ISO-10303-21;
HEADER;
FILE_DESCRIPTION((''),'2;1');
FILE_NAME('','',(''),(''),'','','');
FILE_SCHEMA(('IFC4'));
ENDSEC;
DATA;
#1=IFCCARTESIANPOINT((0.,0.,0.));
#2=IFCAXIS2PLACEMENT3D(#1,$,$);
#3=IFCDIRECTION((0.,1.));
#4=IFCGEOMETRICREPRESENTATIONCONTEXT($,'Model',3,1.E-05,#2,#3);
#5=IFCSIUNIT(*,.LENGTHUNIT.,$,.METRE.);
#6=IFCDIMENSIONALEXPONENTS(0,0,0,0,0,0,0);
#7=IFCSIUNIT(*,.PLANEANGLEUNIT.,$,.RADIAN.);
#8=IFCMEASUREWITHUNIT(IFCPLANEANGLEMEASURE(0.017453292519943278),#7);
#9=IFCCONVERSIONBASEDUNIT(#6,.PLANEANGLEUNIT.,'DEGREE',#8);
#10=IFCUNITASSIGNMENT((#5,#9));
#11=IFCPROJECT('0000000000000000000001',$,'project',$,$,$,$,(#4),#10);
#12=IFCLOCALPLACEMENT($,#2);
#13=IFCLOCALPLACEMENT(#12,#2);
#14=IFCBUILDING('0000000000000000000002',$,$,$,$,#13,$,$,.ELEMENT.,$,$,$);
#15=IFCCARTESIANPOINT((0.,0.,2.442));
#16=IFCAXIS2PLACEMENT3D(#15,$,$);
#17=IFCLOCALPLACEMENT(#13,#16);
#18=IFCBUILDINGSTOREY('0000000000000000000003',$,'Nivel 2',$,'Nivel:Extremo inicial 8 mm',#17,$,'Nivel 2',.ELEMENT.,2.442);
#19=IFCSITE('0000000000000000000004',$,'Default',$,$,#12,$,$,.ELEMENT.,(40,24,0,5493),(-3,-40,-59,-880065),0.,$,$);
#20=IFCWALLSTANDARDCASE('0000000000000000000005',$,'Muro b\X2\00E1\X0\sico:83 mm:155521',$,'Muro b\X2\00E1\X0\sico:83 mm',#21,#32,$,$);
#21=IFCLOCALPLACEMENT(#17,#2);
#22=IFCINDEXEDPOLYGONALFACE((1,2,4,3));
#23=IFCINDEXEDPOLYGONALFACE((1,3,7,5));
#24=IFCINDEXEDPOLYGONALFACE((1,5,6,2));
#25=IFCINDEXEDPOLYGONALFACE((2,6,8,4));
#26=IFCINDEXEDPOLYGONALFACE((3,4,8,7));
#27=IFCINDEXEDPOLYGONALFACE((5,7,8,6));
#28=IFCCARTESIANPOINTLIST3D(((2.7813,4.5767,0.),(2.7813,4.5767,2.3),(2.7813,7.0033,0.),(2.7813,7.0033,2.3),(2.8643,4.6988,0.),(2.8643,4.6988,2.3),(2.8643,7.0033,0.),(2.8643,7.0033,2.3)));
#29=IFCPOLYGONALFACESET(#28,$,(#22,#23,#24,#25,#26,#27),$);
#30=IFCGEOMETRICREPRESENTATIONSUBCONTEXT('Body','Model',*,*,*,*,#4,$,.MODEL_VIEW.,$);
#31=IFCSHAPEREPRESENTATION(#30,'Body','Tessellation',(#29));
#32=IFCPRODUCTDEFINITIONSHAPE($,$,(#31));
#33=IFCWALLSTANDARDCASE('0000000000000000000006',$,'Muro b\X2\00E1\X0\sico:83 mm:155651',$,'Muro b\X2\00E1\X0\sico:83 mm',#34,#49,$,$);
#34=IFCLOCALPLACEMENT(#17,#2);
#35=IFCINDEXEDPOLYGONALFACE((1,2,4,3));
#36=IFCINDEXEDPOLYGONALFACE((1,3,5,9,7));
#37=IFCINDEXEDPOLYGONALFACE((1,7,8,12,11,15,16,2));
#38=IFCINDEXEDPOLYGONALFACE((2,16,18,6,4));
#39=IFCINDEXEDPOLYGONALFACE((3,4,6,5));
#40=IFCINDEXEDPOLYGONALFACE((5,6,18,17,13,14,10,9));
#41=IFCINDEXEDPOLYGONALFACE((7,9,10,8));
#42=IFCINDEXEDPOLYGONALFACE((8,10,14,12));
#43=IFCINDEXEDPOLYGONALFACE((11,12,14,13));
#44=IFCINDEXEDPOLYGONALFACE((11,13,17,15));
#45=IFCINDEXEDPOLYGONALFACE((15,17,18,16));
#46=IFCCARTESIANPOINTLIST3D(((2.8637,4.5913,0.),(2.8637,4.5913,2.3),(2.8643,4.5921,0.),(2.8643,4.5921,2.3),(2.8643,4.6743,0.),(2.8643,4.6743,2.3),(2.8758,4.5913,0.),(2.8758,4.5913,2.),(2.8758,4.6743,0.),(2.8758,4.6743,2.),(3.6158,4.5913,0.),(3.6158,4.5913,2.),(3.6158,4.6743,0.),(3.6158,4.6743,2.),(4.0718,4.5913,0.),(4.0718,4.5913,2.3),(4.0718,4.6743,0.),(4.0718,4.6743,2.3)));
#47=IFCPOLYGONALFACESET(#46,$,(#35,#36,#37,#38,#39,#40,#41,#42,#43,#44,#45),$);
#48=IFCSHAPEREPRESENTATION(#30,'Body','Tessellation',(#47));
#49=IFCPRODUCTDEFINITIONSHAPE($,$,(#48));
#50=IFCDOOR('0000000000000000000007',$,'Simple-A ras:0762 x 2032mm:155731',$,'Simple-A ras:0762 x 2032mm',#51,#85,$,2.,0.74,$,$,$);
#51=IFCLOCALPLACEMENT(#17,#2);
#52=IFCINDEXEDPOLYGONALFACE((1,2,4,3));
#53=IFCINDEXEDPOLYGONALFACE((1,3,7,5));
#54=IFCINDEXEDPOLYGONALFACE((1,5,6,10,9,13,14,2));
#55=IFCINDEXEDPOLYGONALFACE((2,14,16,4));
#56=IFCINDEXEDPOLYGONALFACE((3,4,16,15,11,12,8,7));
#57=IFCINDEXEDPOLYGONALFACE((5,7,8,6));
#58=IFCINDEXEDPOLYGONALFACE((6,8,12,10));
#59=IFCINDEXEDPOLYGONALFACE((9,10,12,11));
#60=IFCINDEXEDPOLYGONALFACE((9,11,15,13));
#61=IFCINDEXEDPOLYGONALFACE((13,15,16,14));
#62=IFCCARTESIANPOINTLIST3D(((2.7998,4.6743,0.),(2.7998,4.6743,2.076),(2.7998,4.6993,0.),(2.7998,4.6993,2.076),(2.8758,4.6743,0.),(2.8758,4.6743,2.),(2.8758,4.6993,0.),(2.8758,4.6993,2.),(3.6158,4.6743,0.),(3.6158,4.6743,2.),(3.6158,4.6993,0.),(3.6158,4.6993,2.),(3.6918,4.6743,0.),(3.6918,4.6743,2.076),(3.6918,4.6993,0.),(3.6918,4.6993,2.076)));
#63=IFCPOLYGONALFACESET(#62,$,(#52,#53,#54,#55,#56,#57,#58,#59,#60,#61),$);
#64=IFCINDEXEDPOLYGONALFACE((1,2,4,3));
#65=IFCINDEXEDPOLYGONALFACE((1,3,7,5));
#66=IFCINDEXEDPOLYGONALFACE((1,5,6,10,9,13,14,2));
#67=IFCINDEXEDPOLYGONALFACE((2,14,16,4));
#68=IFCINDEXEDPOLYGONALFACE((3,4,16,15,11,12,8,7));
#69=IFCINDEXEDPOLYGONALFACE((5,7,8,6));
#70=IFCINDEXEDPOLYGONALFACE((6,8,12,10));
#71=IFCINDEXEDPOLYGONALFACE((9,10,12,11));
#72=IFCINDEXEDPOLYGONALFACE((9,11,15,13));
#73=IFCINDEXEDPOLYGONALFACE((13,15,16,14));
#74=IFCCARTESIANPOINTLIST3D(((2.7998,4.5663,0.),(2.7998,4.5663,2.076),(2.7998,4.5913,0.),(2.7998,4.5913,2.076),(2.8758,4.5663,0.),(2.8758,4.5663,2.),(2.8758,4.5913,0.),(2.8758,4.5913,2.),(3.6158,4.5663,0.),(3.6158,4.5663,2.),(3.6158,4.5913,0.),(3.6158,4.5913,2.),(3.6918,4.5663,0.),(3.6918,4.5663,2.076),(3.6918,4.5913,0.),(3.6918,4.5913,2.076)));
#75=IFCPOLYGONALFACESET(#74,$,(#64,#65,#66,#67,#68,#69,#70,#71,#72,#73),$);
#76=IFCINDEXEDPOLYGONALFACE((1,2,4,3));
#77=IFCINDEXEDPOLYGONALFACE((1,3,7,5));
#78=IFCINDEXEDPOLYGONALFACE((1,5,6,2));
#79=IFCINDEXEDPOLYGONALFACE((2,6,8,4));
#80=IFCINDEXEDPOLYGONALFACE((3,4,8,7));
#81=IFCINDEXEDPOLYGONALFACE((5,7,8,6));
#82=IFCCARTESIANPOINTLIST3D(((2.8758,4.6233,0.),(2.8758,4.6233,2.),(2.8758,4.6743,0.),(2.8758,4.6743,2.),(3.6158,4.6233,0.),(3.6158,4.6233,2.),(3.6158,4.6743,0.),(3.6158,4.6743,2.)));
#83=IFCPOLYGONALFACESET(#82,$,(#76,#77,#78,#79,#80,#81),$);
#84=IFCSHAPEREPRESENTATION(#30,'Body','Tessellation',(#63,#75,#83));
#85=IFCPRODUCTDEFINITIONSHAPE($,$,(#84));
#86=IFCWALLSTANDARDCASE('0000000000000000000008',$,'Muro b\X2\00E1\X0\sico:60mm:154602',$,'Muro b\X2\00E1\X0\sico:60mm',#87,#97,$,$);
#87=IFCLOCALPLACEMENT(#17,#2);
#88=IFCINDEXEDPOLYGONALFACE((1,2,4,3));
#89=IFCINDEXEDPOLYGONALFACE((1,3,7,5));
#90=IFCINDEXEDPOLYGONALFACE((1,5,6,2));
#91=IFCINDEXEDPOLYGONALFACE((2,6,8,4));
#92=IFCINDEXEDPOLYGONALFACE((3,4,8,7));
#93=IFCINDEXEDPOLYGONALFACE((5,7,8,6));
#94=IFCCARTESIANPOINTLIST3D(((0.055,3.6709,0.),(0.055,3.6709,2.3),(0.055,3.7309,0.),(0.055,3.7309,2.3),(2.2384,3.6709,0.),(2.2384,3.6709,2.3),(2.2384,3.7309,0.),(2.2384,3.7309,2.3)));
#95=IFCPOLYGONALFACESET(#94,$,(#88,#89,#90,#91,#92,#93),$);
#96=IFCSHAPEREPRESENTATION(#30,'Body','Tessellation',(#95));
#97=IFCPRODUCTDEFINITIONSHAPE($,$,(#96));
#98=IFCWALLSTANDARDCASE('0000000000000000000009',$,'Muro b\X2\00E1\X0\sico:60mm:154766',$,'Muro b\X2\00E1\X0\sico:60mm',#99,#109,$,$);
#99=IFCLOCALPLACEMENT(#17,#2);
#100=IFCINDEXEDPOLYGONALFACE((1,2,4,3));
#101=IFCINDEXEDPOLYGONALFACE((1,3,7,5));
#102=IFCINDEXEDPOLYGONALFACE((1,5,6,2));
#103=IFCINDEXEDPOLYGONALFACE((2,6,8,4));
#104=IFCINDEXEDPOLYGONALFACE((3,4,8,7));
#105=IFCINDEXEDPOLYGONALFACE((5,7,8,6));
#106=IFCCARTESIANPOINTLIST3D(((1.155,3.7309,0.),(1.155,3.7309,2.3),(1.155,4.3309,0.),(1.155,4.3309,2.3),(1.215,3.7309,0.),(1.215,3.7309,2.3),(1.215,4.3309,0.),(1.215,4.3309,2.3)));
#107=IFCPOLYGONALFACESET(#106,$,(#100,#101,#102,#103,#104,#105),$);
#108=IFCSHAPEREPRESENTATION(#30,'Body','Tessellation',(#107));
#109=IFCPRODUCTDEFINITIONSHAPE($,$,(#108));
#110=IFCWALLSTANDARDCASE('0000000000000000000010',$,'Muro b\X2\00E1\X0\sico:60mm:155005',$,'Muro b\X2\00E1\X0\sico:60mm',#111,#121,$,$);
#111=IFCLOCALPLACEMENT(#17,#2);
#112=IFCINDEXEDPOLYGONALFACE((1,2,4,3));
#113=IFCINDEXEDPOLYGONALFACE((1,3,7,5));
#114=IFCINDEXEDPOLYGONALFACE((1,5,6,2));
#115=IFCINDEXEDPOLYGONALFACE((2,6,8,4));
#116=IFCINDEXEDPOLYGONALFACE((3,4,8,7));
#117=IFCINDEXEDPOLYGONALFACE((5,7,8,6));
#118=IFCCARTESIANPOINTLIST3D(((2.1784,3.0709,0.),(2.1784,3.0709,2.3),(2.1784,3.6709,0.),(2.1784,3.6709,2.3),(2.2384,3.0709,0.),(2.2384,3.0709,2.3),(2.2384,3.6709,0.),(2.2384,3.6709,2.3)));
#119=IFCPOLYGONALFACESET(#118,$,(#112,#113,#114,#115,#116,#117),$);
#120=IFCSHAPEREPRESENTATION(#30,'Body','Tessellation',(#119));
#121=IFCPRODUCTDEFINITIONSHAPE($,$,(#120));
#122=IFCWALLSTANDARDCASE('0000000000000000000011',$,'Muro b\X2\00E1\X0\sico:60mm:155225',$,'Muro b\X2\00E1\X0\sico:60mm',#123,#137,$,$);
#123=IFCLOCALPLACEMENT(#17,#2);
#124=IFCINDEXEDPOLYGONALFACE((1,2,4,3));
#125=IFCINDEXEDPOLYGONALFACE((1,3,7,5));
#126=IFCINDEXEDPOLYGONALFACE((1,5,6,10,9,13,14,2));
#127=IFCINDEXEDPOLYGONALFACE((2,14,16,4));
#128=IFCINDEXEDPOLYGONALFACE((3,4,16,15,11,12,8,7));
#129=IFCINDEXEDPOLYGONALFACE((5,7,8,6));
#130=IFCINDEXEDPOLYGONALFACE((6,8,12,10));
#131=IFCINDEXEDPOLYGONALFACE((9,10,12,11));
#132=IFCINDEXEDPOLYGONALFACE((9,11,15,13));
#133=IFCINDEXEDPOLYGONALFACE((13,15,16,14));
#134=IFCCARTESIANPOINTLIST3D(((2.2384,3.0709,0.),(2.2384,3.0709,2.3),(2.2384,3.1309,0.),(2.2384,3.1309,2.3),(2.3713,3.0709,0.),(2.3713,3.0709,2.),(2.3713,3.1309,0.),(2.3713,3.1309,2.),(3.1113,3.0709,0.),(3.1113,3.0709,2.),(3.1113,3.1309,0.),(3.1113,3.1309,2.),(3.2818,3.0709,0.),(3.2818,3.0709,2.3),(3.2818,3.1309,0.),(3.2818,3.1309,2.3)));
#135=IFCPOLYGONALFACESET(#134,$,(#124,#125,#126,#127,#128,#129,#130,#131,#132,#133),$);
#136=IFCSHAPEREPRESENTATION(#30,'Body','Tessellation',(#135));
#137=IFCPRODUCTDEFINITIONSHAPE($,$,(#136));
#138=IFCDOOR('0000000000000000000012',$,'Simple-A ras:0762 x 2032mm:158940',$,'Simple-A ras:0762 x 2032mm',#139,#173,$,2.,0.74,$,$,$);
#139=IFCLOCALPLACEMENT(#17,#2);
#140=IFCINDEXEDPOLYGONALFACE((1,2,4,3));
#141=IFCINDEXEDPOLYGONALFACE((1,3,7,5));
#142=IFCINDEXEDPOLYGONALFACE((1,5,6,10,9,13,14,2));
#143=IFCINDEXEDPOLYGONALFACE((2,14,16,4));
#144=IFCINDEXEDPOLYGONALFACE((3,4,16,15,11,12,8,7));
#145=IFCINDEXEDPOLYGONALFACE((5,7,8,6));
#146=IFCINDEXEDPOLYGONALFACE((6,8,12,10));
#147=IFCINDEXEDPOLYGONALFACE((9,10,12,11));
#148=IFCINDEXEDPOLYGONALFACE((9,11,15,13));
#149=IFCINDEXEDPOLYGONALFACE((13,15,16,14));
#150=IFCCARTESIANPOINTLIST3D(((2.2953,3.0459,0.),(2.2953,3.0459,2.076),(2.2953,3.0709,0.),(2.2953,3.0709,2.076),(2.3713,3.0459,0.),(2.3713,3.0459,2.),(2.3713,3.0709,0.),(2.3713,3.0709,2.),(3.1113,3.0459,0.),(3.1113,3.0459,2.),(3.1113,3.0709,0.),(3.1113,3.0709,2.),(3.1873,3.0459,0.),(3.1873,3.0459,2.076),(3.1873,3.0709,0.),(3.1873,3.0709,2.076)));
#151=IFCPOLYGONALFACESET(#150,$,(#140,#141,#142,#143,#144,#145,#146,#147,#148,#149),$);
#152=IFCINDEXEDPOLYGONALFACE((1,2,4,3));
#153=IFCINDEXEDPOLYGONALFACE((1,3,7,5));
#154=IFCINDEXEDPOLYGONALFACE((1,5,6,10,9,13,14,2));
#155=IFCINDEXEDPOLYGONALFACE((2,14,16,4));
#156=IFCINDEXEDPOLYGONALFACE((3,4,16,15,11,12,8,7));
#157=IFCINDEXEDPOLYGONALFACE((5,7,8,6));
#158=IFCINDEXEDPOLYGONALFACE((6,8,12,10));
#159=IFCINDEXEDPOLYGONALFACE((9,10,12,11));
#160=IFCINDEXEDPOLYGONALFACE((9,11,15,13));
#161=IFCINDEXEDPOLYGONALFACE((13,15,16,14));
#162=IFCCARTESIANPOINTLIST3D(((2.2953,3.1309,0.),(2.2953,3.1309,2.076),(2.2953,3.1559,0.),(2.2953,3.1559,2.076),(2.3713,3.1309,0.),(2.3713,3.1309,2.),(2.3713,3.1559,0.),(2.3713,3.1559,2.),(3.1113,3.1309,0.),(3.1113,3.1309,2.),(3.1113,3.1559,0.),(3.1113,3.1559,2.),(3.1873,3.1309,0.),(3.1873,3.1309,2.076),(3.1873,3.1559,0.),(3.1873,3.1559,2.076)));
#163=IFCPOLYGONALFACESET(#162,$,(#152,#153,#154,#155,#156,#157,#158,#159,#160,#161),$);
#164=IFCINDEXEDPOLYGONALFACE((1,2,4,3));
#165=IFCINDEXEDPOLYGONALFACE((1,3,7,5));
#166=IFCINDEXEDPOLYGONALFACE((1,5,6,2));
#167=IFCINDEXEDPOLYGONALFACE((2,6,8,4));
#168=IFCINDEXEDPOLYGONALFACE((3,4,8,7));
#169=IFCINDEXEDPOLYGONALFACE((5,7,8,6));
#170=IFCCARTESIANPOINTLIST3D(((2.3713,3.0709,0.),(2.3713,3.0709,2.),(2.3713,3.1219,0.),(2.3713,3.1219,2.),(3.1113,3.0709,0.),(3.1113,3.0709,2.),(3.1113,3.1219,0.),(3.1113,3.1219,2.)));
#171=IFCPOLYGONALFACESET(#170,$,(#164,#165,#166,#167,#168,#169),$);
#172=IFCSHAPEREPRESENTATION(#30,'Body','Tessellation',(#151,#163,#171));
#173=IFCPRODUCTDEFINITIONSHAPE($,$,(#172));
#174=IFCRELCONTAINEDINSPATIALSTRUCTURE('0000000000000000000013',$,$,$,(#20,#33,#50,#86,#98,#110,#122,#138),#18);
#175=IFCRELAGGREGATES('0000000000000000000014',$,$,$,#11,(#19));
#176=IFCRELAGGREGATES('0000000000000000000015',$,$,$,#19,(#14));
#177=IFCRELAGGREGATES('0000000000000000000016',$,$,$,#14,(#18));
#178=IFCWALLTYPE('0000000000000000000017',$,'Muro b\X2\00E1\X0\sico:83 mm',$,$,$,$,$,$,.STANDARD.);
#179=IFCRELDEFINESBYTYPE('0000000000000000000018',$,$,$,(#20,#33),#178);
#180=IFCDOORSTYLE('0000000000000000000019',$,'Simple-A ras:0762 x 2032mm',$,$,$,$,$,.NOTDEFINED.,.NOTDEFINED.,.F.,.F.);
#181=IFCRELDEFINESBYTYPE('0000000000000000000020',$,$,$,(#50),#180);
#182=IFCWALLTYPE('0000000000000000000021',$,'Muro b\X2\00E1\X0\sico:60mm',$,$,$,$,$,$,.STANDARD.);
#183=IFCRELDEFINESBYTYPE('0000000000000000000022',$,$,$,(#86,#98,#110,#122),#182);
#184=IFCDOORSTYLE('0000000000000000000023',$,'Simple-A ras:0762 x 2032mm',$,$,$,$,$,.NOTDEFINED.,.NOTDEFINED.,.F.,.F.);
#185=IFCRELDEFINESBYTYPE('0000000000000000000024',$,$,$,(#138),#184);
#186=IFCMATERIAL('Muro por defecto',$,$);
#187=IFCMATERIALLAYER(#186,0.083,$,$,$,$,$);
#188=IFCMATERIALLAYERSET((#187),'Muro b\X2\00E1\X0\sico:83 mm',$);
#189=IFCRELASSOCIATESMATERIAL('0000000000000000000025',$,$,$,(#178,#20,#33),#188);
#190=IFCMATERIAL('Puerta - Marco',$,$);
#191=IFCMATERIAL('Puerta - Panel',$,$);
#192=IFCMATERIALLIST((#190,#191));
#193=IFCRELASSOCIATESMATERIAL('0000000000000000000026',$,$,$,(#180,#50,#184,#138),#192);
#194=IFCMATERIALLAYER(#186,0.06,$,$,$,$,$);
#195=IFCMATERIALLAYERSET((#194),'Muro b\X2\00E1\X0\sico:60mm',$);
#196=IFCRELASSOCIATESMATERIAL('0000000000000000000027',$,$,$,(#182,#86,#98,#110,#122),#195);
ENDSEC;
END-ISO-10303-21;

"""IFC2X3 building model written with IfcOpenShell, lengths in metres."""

from ifc_helpers import new_model, entity, si_unit, converted_unit, direction, frame, frame_2d, origin, origin_2d_with_axis, place, context, subcontext, project, spatial, polyline, rectangle, outline, extrude, source, transform, mapped, material, material_list, layer, layer_set, layer_usage, type_object, type_shapes, element, fill, save


model = new_model("IFC2X3")

# Units and contexts
model_context = context("Model", 3, precision=1e-05, world=origin(), true_north=direction((0.0, 1.0)))
body_context = subcontext(model_context, "Body", "Model", "MODEL_VIEW")
ifc_project = project(units=[si_unit("LENGTHUNIT", "METRE"), converted_unit("PLANEANGLEUNIT", "DEGREE", entity("IfcPlaneAngleMeasure", 0.017453292519943278), si_unit("PLANEANGLEUNIT", "RADIAN"), dimensions=[0, 0, 0, 0, 0, 0, 0])], contexts=[model_context])

# Site, building, storey
site_placement = place(None, origin())
site = spatial("IfcSite", under=ifc_project, at=site_placement, Name="Default", CompositionType="ELEMENT", RefLatitude=(40, 24, 0, 5493), RefLongitude=(-3, -40, -59, -880065), RefElevation=0.0)
building_placement = place(site_placement, origin())
building = spatial("IfcBuilding", under=site, at=building_placement, CompositionType="ELEMENT")
storey_placement = place(building_placement, frame((0.0, 0.0, 2.442)))
storey = spatial("IfcBuildingStorey", under=building, at=storey_placement, Name="Nivel 2", ObjectType="Nivel:Extremo inicial 8 mm", LongName="Nivel 2", CompositionType="ELEMENT", Elevation=2.442)

# Shared definitions
ifc_material_1 = material(Name="Muro por defecto")

# Wall
ifc_layer_1 = layer(ifc_material_1, 0.083)
ifc_layer_set_1 = layer_set([ifc_layer_1], Name="Muro básico:83 mm")
ifc_layer_usage_1 = layer_usage(ifc_layer_set_1, "AXIS2", "NEGATIVE", 0.0415)
wall_type_1 = type_object("IfcWallType", Name="Muro básico:83 mm", PredefinedType="STANDARD", material=ifc_layer_set_1)
wall_1_placement = place(storey_placement, frame((2.8228, 4.5767, 0.0), z_axis=(0.0, 0.0, 1.0), x_axis=(0.0, 1.0, 0.0)))
element("IfcWallStandardCase", 1, at=wall_1_placement, inside=storey, type_object=wall_type_1, material=ifc_layer_usage_1, Name="Muro básico:83 mm:155521", ObjectType="Muro básico:83 mm", context=body_context, shape_type="SweptSolid", body=[
    extrude(outline(polyline([(2.4266, -0.0415), (2.4266, 0.0415), (0.0, 0.0415), (0.1222, -0.0415), (2.4266, -0.0415)])), origin(), (0.0, 0.0, 1.0), 2.3),
])

# Wall, opening, door
ifc_layer_usage_2 = layer_usage(ifc_layer_set_1, "AXIS2", "NEGATIVE", 0.0415)
wall_2_placement = place(storey_placement, frame((4.0718, 4.6328, 0.0), z_axis=(0.0, 0.0, 1.0), x_axis=(-1.0, 0.0, 0.0)))
wall_2 = element("IfcWallStandardCase", 2, at=wall_2_placement, inside=storey, type_object=wall_type_1, material=ifc_layer_usage_2, Name="Muro básico:83 mm:155651", ObjectType="Muro básico:83 mm", context=body_context, shape_type="SweptSolid", body=[
    extrude(outline(polyline([(0.0, -0.0415), (1.2075, -0.0415), (1.2075, 0.0407), (1.2081, 0.0415), (0.0, 0.0415), (0.0, -0.0415)])), origin(), (0.0, 0.0, 1.0), 2.3),
])
opening_1_placement = place(wall_2_placement, frame((1.196, 0.0415, 0.0)))
opening_1 = element("IfcOpeningElement", 3, at=opening_1_placement, cuts=wall_2, ObjectType="Opening", context=body_context, shape_type="SweptSolid", body=[
    extrude(rectangle(XDim=0.74, YDim=2.0, at=frame_2d((1.0, 0.37), x_axis=(0.0, -1.0))), frame((0.0, 0.0, 0.0), z_axis=(0.0, -1.0, 0.0), x_axis=(0.0, 0.0, 1.0)), (0.0, 0.0, 1.0), 0.083),
])
ifc_material_2 = material(Name="Puerta - Marco")
ifc_material_3 = material(Name="Puerta - Panel")
ifc_material_list_1 = material_list([ifc_material_2, ifc_material_3])
door_style_1 = type_object("IfcDoorStyle", Name="Simple-A ras:0762 x 2032mm", ConstructionType="NOTDEFINED", OperationType="NOTDEFINED", ParameterTakesPrecedence=False, Sizeable=False, material=ifc_material_list_1)
shared_shape_1 = source(origin(), body_context, "Body", "SweptSolid", [
    extrude(outline(polyline([(-0.446, -1.057), (0.446, -1.057), (0.446, 1.019), (0.37, 1.019), (0.37, -0.981), (-0.37, -0.981), (-0.37, 1.019), (-0.446, 1.019), (-0.446, -1.057)])), frame((0.37, 0.108, 1.019), z_axis=(0.0, -1.0, 0.0), x_axis=(-1.0, 0.0, 0.0)), (0.0, 0.0, 1.0), 0.025),
    extrude(outline(polyline([(-1.057, -0.446), (1.019, -0.446), (1.019, -0.37), (-0.981, -0.37), (-0.981, 0.37), (1.019, 0.37), (1.019, 0.446), (-1.057, 0.446), (-1.057, -0.446)])), frame((0.37, 0.0, 1.019), z_axis=(0.0, -1.0, 0.0), x_axis=(0.0, 0.0, -1.0)), (0.0, 0.0, 1.0), 0.025),
    extrude(rectangle(XDim=0.74, YDim=0.051, at=origin_2d_with_axis()), frame((0.37, 0.0575, 0.0)), (0.0, 0.0, 1.0), 2.0),
])
type_shapes(door_style_1, [shared_shape_1])
door_1_placement = place(opening_1_placement, frame((0.0, 0.0, 0.0), z_axis=(0.0, 0.0, 1.0), x_axis=(-1.0, 0.0, 0.0)))
door_1 = element("IfcDoor", 4, at=door_1_placement, inside=storey, type_object=door_style_1, material=ifc_material_list_1, Name="Simple-A ras:0762 x 2032mm:155731", ObjectType="Simple-A ras:0762 x 2032mm", OverallHeight=2.0, OverallWidth=0.74, context=body_context, shape_type="MappedRepresentation", body=[
    mapped(shared_shape_1, transform((0.0, 0.0, 0.0), scale=1.0)),
])
fill(opening_1, door_1)

# Walls
ifc_layer_2 = layer(ifc_material_1, 0.06)
ifc_layer_set_2 = layer_set([ifc_layer_2], Name="Muro básico:60mm")
ifc_layer_usage_3 = layer_usage(ifc_layer_set_2, "AXIS2", "NEGATIVE", 0.03)
wall_type_2 = type_object("IfcWallType", Name="Muro básico:60mm", PredefinedType="STANDARD", material=ifc_layer_set_2)
wall_3_placement = place(storey_placement, frame((0.055, 3.7009, 0.0)))
element("IfcWallStandardCase", 5, at=wall_3_placement, inside=storey, type_object=wall_type_2, material=ifc_layer_usage_3, Name="Muro básico:60mm:154602", ObjectType="Muro básico:60mm", context=body_context, shape_type="SweptSolid", body=[
    extrude(rectangle(XDim=2.1834, YDim=0.06, at=frame_2d((1.0917, 0.0), x_axis=(-1.0, 0.0))), origin(), (0.0, 0.0, 1.0), 2.3),
])
ifc_layer_usage_4 = layer_usage(ifc_layer_set_2, "AXIS2", "NEGATIVE", 0.03)
wall_4_placement = place(storey_placement, frame((1.185, 3.7309, 0.0), z_axis=(0.0, 0.0, 1.0), x_axis=(0.0, 1.0, 0.0)))
element("IfcWallStandardCase", 6, at=wall_4_placement, inside=storey, type_object=wall_type_2, material=ifc_layer_usage_4, Name="Muro básico:60mm:154766", ObjectType="Muro básico:60mm", context=body_context, shape_type="SweptSolid", body=[
    extrude(rectangle(XDim=0.6, YDim=0.06, at=frame_2d((0.3, 0.0), x_axis=(-1.0, 0.0))), origin(), (0.0, 0.0, 1.0), 2.3),
])
ifc_layer_usage_5 = layer_usage(ifc_layer_set_2, "AXIS2", "NEGATIVE", 0.03)
wall_5_placement = place(storey_placement, frame((2.2084, 3.0709, 0.0), z_axis=(0.0, 0.0, 1.0), x_axis=(0.0, 1.0, 0.0)))
element("IfcWallStandardCase", 7, at=wall_5_placement, inside=storey, type_object=wall_type_2, material=ifc_layer_usage_5, Name="Muro básico:60mm:155005", ObjectType="Muro básico:60mm", context=body_context, shape_type="SweptSolid", body=[
    extrude(rectangle(XDim=0.6, YDim=0.06, at=frame_2d((0.3, 0.0), x_axis=(-1.0, 0.0))), origin(), (0.0, 0.0, 1.0), 2.3),
])

# Wall, opening, door
ifc_layer_usage_6 = layer_usage(ifc_layer_set_2, "AXIS2", "NEGATIVE", 0.03)
wall_6_placement = place(storey_placement, frame((2.2384, 3.1009, 0.0)))
wall_6 = element("IfcWallStandardCase", 8, at=wall_6_placement, inside=storey, type_object=wall_type_2, material=ifc_layer_usage_6, Name="Muro básico:60mm:155225", ObjectType="Muro básico:60mm", context=body_context, shape_type="SweptSolid", body=[
    extrude(rectangle(XDim=1.0434, YDim=0.06, at=frame_2d((0.5217, 0.0), x_axis=(-1.0, 0.0))), origin(), (0.0, 0.0, 1.0), 2.3),
])
opening_2_placement = place(wall_6_placement, frame((0.8729, 0.03, 0.0)))
opening_2 = element("IfcOpeningElement", 9, at=opening_2_placement, cuts=wall_6, ObjectType="Opening", context=body_context, shape_type="SweptSolid", body=[
    extrude(rectangle(XDim=0.74, YDim=2.0, at=frame_2d((1.0, 0.37), x_axis=(0.0, -1.0))), frame((0.0, 0.0, 0.0), z_axis=(0.0, -1.0, 0.0), x_axis=(0.0, 0.0, 1.0)), (0.0, 0.0, 1.0), 0.06),
])
door_style_2 = type_object("IfcDoorStyle", Name="Simple-A ras:0762 x 2032mm", ConstructionType="NOTDEFINED", OperationType="NOTDEFINED", ParameterTakesPrecedence=False, Sizeable=False, material=ifc_material_list_1)
shared_shape_2 = source(origin(), body_context, "Body", "SweptSolid", [
    extrude(outline(polyline([(-0.446, -1.057), (0.446, -1.057), (0.446, 1.019), (0.37, 1.019), (0.37, -0.981), (-0.37, -0.981), (-0.37, 1.019), (-0.446, 1.019), (-0.446, -1.057)])), frame((0.37, 0.085, 1.019), z_axis=(0.0, -1.0, 0.0), x_axis=(-1.0, 0.0, 0.0)), (0.0, 0.0, 1.0), 0.025),
    extrude(outline(polyline([(-1.057, -0.446), (1.019, -0.446), (1.019, -0.37), (-0.981, -0.37), (-0.981, 0.37), (1.019, 0.37), (1.019, 0.446), (-1.057, 0.446), (-1.057, -0.446)])), frame((0.37, 0.0, 1.019), z_axis=(0.0, -1.0, 0.0), x_axis=(0.0, 0.0, -1.0)), (0.0, 0.0, 1.0), 0.025),
    extrude(rectangle(XDim=0.74, YDim=0.051, at=origin_2d_with_axis()), frame((0.37, 0.0345, 0.0)), (0.0, 0.0, 1.0), 2.0),
])
type_shapes(door_style_2, [shared_shape_2])
door_2_placement = place(opening_2_placement, frame((0.0, 0.0, 0.0), z_axis=(0.0, 0.0, 1.0), x_axis=(-1.0, 0.0, 0.0)))
door_2 = element("IfcDoor", 10, at=door_2_placement, inside=storey, type_object=door_style_2, material=ifc_material_list_1, Name="Simple-A ras:0762 x 2032mm:158940", ObjectType="Simple-A ras:0762 x 2032mm", OverallHeight=2.0, OverallWidth=0.74, context=body_context, shape_type="MappedRepresentation", body=[
    mapped(shared_shape_2, transform((0.0, 0.0, 0.0), scale=1.0)),
])
fill(opening_2, door_2)

save(model, "model.ifc")
